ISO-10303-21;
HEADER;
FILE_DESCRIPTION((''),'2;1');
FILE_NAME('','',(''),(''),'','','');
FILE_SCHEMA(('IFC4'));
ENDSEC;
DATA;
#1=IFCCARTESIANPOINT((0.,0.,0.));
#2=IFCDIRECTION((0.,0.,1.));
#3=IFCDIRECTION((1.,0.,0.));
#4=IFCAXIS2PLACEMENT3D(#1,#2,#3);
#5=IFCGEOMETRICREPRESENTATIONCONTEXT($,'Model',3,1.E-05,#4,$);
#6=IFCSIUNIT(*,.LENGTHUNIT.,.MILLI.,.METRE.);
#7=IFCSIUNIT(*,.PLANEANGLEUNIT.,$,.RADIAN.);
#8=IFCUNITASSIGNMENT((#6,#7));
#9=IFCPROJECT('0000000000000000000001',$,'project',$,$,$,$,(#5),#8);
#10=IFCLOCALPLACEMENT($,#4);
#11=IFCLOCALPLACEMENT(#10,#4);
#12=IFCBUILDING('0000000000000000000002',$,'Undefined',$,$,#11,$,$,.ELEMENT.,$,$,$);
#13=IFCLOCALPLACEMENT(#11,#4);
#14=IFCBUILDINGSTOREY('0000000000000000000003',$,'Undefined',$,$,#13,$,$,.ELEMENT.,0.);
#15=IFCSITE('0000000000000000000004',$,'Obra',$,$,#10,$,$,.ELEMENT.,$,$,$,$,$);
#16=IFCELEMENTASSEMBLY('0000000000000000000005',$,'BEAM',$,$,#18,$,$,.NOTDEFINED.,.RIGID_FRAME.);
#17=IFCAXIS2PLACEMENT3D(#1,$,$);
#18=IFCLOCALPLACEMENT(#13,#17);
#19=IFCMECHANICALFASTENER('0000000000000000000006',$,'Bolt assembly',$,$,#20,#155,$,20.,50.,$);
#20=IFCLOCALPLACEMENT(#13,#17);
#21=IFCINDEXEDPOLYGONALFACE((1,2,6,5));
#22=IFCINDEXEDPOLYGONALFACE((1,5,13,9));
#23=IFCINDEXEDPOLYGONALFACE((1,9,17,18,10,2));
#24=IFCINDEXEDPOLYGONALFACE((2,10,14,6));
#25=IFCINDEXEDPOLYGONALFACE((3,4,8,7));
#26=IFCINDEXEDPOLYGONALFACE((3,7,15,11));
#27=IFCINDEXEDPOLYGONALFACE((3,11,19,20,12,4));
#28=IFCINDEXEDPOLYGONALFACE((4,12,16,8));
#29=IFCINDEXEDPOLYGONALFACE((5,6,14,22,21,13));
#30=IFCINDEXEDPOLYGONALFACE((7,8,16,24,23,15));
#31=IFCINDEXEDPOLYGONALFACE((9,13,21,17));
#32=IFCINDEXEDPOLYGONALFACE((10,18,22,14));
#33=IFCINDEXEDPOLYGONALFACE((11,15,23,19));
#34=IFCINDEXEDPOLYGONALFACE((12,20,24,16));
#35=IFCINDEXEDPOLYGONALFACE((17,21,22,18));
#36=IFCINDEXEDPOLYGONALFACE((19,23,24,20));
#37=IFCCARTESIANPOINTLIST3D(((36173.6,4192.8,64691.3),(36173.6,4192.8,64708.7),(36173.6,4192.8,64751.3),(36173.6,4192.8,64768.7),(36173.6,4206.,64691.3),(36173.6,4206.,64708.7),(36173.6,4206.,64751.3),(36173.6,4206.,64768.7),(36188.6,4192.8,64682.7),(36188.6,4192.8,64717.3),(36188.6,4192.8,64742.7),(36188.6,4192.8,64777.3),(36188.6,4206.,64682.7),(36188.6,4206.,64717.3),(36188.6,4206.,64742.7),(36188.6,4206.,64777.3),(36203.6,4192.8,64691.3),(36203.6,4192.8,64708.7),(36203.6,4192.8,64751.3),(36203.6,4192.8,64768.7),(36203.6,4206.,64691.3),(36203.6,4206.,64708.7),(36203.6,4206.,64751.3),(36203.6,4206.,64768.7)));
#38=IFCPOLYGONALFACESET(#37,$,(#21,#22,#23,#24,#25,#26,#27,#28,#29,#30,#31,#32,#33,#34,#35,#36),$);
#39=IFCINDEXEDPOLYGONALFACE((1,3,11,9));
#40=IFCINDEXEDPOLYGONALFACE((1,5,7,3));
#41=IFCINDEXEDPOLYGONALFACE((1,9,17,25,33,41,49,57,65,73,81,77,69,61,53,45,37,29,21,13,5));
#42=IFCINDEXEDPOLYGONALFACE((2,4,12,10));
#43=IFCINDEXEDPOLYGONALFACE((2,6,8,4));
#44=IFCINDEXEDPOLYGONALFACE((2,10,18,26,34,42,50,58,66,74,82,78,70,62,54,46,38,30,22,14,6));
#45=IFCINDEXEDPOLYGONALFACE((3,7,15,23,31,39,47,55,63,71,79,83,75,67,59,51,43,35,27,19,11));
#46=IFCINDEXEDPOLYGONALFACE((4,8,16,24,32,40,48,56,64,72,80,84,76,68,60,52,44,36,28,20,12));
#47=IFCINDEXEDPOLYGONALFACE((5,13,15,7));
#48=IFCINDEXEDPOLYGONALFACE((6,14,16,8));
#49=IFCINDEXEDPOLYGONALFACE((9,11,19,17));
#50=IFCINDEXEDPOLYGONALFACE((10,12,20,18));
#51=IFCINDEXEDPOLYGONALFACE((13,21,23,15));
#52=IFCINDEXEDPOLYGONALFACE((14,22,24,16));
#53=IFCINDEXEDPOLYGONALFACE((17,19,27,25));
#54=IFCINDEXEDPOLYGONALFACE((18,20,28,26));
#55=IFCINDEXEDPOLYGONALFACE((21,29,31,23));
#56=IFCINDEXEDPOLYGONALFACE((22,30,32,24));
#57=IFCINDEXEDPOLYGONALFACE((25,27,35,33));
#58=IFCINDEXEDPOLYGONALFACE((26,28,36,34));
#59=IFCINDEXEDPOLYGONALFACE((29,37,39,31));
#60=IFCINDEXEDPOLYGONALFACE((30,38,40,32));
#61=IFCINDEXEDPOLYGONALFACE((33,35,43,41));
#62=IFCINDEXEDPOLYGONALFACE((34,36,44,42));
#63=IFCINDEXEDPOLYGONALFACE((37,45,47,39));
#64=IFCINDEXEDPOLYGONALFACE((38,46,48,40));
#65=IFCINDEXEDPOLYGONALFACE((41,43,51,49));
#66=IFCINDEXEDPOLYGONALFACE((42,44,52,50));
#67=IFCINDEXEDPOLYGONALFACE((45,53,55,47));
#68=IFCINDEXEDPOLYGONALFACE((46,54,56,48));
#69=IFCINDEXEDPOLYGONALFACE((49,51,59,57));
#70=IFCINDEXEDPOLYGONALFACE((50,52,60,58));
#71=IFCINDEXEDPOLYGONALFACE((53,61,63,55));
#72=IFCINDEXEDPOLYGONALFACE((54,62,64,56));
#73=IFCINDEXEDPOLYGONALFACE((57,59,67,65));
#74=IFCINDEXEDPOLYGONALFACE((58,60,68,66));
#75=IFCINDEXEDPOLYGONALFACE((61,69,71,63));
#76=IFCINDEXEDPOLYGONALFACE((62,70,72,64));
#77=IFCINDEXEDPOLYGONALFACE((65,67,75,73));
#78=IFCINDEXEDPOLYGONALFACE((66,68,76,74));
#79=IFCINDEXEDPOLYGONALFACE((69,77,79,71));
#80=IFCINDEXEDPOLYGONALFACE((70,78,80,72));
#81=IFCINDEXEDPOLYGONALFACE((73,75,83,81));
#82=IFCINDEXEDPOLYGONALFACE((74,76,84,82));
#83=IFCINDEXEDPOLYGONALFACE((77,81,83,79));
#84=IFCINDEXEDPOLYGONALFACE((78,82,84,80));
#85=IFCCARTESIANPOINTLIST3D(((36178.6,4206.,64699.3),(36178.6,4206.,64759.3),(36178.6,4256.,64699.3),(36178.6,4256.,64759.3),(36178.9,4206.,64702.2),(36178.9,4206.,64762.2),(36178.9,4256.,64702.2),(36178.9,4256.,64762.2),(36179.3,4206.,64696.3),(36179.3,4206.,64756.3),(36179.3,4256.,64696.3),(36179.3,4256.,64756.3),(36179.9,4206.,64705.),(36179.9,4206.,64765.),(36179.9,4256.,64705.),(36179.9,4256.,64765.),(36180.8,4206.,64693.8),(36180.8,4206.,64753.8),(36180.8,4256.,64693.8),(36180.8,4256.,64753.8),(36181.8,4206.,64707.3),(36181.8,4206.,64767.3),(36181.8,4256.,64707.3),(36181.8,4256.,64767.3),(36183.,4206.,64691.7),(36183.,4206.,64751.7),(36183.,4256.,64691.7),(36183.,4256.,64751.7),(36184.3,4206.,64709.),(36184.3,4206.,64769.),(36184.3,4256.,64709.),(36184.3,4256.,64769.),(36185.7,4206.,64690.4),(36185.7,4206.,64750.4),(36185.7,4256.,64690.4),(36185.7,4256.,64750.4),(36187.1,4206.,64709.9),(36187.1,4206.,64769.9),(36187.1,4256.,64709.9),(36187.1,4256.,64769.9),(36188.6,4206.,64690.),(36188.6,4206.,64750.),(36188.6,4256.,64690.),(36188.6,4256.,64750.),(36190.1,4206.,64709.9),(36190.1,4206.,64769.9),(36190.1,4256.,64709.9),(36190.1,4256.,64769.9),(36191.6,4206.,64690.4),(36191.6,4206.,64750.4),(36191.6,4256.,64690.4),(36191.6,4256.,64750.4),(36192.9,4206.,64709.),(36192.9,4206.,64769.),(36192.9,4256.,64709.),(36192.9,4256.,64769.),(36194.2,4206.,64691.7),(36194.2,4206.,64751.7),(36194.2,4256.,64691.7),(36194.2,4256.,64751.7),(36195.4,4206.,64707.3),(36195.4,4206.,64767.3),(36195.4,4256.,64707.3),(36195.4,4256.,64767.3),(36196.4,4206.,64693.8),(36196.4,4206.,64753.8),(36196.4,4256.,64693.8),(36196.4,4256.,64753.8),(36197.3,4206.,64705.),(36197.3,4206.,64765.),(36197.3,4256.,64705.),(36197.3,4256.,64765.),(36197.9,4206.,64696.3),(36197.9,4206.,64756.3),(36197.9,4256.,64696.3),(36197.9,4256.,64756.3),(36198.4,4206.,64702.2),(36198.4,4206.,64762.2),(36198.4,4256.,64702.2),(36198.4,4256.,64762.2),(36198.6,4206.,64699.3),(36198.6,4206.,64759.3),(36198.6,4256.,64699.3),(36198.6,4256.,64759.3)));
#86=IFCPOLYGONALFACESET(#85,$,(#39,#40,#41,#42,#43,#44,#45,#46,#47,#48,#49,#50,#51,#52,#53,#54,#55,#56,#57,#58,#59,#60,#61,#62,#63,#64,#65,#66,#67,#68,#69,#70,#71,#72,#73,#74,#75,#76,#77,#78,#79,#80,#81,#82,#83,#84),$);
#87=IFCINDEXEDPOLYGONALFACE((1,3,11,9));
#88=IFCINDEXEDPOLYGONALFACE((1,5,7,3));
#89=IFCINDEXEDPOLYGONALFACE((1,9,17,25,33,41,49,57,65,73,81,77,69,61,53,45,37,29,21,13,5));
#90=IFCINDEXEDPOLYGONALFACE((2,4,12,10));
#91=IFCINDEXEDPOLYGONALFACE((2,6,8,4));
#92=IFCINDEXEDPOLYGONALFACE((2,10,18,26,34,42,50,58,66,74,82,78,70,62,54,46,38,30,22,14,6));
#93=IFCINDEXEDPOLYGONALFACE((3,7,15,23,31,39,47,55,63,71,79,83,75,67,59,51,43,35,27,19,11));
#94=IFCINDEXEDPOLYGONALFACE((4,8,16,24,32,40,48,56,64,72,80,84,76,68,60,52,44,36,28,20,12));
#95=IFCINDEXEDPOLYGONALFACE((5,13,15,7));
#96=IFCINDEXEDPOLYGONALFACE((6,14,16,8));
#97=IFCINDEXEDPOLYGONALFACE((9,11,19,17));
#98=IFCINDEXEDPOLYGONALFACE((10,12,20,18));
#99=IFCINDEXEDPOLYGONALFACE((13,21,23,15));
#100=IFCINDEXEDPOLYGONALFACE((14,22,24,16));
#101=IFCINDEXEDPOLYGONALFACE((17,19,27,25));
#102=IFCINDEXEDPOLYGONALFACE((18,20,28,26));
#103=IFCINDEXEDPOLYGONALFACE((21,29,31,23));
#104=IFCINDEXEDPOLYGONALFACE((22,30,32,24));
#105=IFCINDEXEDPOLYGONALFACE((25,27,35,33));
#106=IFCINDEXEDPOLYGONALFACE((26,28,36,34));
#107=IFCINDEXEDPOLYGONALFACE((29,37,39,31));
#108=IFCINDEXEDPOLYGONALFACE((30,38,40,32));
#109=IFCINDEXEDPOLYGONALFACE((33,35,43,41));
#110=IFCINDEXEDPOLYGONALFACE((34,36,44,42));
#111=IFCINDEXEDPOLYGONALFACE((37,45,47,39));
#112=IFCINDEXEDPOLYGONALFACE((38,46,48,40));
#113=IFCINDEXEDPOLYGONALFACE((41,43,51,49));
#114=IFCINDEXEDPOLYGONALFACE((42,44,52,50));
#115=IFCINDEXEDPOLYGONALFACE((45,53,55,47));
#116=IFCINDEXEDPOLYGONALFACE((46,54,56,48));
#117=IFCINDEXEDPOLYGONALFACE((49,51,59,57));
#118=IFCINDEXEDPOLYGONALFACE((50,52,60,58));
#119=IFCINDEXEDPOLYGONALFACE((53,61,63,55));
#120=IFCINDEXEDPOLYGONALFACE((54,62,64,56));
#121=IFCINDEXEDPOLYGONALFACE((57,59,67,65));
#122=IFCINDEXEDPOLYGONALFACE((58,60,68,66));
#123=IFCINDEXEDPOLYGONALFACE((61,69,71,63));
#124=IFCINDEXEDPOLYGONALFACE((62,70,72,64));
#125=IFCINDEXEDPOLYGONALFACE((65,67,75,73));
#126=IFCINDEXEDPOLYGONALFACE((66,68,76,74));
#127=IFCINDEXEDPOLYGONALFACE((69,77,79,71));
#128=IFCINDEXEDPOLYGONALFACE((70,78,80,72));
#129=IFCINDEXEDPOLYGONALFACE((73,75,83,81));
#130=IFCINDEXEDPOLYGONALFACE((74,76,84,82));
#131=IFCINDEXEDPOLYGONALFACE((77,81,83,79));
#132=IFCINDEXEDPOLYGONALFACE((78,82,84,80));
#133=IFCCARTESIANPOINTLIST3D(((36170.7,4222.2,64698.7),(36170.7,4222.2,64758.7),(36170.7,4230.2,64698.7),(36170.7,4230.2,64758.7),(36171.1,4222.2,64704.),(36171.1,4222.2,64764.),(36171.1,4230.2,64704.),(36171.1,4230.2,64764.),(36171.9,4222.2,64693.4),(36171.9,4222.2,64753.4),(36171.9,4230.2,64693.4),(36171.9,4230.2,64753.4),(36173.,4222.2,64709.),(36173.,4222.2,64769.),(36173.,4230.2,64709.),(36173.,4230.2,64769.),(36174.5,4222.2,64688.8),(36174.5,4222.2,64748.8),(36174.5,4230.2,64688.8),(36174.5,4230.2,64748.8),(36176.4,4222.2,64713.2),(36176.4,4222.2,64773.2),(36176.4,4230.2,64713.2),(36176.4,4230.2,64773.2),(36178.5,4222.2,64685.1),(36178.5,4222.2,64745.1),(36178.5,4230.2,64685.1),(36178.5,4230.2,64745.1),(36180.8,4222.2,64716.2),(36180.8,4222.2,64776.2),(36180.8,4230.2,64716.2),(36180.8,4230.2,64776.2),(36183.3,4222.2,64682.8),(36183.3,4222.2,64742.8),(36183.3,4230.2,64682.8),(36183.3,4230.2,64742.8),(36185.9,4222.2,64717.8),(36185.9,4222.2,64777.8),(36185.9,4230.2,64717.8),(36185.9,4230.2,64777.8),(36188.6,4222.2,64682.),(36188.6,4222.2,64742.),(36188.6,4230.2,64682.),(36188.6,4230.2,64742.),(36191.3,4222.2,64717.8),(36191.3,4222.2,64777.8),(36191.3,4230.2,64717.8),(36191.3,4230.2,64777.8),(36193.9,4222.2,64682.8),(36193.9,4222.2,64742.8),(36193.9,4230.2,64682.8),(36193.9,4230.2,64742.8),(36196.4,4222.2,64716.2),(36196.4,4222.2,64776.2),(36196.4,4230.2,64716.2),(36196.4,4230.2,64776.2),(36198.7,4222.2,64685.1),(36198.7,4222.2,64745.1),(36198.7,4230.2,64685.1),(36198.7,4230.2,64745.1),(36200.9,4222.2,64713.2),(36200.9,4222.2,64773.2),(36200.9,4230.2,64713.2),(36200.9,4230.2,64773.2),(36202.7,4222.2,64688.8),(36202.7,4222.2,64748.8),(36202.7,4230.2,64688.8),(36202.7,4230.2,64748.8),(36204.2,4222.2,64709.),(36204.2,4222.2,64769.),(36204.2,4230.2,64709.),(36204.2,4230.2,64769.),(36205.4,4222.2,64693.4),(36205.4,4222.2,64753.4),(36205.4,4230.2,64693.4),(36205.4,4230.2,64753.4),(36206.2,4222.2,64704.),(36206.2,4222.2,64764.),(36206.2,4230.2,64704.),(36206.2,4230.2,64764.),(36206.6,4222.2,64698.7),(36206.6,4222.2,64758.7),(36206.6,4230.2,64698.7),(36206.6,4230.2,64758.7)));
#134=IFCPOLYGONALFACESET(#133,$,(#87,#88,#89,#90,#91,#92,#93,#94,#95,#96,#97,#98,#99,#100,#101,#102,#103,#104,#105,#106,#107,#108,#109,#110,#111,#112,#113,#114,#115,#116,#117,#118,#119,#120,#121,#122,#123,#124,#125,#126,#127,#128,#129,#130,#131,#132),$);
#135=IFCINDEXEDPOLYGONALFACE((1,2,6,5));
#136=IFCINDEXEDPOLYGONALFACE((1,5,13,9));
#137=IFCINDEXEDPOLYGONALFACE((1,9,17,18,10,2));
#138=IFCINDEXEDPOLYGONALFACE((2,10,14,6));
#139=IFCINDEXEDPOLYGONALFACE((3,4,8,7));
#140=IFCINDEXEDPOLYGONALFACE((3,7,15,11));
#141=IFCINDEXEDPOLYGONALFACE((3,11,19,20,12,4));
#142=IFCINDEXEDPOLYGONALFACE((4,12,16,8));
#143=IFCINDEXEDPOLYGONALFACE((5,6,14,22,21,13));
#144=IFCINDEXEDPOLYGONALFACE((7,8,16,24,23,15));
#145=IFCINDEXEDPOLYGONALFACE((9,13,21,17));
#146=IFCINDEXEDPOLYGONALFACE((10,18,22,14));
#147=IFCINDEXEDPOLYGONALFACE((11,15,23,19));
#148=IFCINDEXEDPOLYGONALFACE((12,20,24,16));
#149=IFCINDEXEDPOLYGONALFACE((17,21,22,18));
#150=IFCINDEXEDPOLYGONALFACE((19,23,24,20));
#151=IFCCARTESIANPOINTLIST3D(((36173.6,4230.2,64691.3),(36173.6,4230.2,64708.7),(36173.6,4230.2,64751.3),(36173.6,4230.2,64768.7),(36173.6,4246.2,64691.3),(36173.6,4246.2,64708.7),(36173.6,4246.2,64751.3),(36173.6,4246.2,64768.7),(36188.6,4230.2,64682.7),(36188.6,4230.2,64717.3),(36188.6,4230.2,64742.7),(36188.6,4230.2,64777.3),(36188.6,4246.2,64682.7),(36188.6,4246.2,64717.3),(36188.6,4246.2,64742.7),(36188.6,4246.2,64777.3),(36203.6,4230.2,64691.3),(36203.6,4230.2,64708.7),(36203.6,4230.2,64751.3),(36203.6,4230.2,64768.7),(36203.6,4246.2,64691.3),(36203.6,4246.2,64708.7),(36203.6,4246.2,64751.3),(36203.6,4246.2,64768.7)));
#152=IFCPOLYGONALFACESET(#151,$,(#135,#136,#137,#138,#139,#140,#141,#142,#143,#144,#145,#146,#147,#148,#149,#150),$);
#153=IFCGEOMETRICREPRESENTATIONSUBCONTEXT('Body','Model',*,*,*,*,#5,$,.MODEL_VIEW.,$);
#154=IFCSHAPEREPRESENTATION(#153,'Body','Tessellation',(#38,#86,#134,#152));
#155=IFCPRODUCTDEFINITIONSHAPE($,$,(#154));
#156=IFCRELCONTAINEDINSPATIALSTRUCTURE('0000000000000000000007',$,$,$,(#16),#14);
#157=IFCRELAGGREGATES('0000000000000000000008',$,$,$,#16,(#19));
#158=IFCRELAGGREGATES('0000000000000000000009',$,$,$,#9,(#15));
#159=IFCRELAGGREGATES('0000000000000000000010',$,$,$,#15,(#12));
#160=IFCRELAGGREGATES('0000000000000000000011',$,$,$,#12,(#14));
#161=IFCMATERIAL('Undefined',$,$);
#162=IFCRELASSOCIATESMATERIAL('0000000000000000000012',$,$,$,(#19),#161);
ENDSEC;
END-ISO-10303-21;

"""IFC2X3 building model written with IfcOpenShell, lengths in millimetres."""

from ifc_helpers import new_model, si_unit, frame, origin_with_axes, origin_2d_with_axis, place, context, subcontext, project, spatial, polyline, circle, outline, extrude, source, transform, mapped, material, element, aggregate, save


model = new_model("IFC2X3")

# Units and contexts
model_context = context("Model", 3, precision=1e-05, world=origin_with_axes())
body_context = subcontext(model_context, "Body", "Model", "MODEL_VIEW")
ifc_project = project(units=[si_unit("LENGTHUNIT", "METRE", prefix="MILLI"), si_unit("PLANEANGLEUNIT", "RADIAN")], contexts=[model_context])

# Site, building, storey
site_placement = place(None, origin_with_axes())
site = spatial("IfcSite", under=ifc_project, at=site_placement, Name="Obra", CompositionType="ELEMENT")
building_placement = place(site_placement, origin_with_axes())
building = spatial("IfcBuilding", under=site, at=building_placement, Name="Undefined", CompositionType="ELEMENT")
storey_placement = place(building_placement, origin_with_axes())
storey = spatial("IfcBuildingStorey", under=building, at=storey_placement, Name="Undefined", CompositionType="ELEMENT", Elevation=0.0)

# Shared definitions
ifc_material = material(Name="Undefined")

# Element assembly, mechanical fastener
shared_shape_1 = source(origin_with_axes(), body_context, "Body", "SweptSolid", [
    extrude(outline(polyline([(17.3, 0.0), (8.7, 15.0), (-8.7, 15.0), (-17.3, 0.0), (-8.7, -15.0), (8.7, -15.0), (17.3, 0.0)])), frame((0.0, -26.3, 0.0), z_axis=(0.0, 1.0, 0.0), x_axis=(1.0, 0.0, 0.0)), (0.0, 0.0, 1.0), 13.2),
    extrude(circle(Radius=10.0, at=origin_2d_with_axis()), frame((0.0, -13.1, 0.0), z_axis=(0.0, 1.0, 0.0), x_axis=(1.0, 0.0, 0.0)), (0.0, 0.0, 1.0), 50.0),
    extrude(circle(Radius=18.0, at=origin_2d_with_axis()), frame((0.0, 3.1, 0.0), z_axis=(0.0, 1.0, 0.0), x_axis=(1.0, 0.0, 0.0)), (0.0, 0.0, 1.0), 8.0),
    extrude(outline(polyline([(17.3, 0.0), (8.7, 15.0), (-8.7, 15.0), (-17.3, 0.0), (-8.7, -15.0), (8.7, -15.0), (17.3, 0.0)])), frame((0.0, 11.1, 0.0), z_axis=(0.0, 1.0, 0.0), x_axis=(1.0, 0.0, 0.0)), (0.0, 0.0, 1.0), 16.0),
])
assembly_1_placement = place(storey_placement, origin_with_axes())
assembly_1 = element("IfcElementAssembly", 1, at=assembly_1_placement, inside=storey, Name="BEAM", AssemblyPlace="NOTDEFINED", PredefinedType="RIGID_FRAME")
mechanical_fastener_1_placement = place(assembly_1_placement, frame((36148.6, 4219.1, 64850.0), z_axis=(1.0, 0.0, 0.0), x_axis=(0.0, 0.0, -1.0)))
mechanical_fastener_1 = element("IfcMechanicalFastener", 2, at=mechanical_fastener_1_placement, material=ifc_material, Name="Bolt assembly", NominalDiameter=20.0, NominalLength=50.0, context=body_context, shape_type="MappedRepresentation", body=[
    mapped(shared_shape_1, transform((90.0, 0.0, 40.0))),
    mapped(shared_shape_1, transform((150.0, 0.0, 40.0))),
])
aggregate(assembly_1, [mechanical_fastener_1])

save(model, "model.ifc")
